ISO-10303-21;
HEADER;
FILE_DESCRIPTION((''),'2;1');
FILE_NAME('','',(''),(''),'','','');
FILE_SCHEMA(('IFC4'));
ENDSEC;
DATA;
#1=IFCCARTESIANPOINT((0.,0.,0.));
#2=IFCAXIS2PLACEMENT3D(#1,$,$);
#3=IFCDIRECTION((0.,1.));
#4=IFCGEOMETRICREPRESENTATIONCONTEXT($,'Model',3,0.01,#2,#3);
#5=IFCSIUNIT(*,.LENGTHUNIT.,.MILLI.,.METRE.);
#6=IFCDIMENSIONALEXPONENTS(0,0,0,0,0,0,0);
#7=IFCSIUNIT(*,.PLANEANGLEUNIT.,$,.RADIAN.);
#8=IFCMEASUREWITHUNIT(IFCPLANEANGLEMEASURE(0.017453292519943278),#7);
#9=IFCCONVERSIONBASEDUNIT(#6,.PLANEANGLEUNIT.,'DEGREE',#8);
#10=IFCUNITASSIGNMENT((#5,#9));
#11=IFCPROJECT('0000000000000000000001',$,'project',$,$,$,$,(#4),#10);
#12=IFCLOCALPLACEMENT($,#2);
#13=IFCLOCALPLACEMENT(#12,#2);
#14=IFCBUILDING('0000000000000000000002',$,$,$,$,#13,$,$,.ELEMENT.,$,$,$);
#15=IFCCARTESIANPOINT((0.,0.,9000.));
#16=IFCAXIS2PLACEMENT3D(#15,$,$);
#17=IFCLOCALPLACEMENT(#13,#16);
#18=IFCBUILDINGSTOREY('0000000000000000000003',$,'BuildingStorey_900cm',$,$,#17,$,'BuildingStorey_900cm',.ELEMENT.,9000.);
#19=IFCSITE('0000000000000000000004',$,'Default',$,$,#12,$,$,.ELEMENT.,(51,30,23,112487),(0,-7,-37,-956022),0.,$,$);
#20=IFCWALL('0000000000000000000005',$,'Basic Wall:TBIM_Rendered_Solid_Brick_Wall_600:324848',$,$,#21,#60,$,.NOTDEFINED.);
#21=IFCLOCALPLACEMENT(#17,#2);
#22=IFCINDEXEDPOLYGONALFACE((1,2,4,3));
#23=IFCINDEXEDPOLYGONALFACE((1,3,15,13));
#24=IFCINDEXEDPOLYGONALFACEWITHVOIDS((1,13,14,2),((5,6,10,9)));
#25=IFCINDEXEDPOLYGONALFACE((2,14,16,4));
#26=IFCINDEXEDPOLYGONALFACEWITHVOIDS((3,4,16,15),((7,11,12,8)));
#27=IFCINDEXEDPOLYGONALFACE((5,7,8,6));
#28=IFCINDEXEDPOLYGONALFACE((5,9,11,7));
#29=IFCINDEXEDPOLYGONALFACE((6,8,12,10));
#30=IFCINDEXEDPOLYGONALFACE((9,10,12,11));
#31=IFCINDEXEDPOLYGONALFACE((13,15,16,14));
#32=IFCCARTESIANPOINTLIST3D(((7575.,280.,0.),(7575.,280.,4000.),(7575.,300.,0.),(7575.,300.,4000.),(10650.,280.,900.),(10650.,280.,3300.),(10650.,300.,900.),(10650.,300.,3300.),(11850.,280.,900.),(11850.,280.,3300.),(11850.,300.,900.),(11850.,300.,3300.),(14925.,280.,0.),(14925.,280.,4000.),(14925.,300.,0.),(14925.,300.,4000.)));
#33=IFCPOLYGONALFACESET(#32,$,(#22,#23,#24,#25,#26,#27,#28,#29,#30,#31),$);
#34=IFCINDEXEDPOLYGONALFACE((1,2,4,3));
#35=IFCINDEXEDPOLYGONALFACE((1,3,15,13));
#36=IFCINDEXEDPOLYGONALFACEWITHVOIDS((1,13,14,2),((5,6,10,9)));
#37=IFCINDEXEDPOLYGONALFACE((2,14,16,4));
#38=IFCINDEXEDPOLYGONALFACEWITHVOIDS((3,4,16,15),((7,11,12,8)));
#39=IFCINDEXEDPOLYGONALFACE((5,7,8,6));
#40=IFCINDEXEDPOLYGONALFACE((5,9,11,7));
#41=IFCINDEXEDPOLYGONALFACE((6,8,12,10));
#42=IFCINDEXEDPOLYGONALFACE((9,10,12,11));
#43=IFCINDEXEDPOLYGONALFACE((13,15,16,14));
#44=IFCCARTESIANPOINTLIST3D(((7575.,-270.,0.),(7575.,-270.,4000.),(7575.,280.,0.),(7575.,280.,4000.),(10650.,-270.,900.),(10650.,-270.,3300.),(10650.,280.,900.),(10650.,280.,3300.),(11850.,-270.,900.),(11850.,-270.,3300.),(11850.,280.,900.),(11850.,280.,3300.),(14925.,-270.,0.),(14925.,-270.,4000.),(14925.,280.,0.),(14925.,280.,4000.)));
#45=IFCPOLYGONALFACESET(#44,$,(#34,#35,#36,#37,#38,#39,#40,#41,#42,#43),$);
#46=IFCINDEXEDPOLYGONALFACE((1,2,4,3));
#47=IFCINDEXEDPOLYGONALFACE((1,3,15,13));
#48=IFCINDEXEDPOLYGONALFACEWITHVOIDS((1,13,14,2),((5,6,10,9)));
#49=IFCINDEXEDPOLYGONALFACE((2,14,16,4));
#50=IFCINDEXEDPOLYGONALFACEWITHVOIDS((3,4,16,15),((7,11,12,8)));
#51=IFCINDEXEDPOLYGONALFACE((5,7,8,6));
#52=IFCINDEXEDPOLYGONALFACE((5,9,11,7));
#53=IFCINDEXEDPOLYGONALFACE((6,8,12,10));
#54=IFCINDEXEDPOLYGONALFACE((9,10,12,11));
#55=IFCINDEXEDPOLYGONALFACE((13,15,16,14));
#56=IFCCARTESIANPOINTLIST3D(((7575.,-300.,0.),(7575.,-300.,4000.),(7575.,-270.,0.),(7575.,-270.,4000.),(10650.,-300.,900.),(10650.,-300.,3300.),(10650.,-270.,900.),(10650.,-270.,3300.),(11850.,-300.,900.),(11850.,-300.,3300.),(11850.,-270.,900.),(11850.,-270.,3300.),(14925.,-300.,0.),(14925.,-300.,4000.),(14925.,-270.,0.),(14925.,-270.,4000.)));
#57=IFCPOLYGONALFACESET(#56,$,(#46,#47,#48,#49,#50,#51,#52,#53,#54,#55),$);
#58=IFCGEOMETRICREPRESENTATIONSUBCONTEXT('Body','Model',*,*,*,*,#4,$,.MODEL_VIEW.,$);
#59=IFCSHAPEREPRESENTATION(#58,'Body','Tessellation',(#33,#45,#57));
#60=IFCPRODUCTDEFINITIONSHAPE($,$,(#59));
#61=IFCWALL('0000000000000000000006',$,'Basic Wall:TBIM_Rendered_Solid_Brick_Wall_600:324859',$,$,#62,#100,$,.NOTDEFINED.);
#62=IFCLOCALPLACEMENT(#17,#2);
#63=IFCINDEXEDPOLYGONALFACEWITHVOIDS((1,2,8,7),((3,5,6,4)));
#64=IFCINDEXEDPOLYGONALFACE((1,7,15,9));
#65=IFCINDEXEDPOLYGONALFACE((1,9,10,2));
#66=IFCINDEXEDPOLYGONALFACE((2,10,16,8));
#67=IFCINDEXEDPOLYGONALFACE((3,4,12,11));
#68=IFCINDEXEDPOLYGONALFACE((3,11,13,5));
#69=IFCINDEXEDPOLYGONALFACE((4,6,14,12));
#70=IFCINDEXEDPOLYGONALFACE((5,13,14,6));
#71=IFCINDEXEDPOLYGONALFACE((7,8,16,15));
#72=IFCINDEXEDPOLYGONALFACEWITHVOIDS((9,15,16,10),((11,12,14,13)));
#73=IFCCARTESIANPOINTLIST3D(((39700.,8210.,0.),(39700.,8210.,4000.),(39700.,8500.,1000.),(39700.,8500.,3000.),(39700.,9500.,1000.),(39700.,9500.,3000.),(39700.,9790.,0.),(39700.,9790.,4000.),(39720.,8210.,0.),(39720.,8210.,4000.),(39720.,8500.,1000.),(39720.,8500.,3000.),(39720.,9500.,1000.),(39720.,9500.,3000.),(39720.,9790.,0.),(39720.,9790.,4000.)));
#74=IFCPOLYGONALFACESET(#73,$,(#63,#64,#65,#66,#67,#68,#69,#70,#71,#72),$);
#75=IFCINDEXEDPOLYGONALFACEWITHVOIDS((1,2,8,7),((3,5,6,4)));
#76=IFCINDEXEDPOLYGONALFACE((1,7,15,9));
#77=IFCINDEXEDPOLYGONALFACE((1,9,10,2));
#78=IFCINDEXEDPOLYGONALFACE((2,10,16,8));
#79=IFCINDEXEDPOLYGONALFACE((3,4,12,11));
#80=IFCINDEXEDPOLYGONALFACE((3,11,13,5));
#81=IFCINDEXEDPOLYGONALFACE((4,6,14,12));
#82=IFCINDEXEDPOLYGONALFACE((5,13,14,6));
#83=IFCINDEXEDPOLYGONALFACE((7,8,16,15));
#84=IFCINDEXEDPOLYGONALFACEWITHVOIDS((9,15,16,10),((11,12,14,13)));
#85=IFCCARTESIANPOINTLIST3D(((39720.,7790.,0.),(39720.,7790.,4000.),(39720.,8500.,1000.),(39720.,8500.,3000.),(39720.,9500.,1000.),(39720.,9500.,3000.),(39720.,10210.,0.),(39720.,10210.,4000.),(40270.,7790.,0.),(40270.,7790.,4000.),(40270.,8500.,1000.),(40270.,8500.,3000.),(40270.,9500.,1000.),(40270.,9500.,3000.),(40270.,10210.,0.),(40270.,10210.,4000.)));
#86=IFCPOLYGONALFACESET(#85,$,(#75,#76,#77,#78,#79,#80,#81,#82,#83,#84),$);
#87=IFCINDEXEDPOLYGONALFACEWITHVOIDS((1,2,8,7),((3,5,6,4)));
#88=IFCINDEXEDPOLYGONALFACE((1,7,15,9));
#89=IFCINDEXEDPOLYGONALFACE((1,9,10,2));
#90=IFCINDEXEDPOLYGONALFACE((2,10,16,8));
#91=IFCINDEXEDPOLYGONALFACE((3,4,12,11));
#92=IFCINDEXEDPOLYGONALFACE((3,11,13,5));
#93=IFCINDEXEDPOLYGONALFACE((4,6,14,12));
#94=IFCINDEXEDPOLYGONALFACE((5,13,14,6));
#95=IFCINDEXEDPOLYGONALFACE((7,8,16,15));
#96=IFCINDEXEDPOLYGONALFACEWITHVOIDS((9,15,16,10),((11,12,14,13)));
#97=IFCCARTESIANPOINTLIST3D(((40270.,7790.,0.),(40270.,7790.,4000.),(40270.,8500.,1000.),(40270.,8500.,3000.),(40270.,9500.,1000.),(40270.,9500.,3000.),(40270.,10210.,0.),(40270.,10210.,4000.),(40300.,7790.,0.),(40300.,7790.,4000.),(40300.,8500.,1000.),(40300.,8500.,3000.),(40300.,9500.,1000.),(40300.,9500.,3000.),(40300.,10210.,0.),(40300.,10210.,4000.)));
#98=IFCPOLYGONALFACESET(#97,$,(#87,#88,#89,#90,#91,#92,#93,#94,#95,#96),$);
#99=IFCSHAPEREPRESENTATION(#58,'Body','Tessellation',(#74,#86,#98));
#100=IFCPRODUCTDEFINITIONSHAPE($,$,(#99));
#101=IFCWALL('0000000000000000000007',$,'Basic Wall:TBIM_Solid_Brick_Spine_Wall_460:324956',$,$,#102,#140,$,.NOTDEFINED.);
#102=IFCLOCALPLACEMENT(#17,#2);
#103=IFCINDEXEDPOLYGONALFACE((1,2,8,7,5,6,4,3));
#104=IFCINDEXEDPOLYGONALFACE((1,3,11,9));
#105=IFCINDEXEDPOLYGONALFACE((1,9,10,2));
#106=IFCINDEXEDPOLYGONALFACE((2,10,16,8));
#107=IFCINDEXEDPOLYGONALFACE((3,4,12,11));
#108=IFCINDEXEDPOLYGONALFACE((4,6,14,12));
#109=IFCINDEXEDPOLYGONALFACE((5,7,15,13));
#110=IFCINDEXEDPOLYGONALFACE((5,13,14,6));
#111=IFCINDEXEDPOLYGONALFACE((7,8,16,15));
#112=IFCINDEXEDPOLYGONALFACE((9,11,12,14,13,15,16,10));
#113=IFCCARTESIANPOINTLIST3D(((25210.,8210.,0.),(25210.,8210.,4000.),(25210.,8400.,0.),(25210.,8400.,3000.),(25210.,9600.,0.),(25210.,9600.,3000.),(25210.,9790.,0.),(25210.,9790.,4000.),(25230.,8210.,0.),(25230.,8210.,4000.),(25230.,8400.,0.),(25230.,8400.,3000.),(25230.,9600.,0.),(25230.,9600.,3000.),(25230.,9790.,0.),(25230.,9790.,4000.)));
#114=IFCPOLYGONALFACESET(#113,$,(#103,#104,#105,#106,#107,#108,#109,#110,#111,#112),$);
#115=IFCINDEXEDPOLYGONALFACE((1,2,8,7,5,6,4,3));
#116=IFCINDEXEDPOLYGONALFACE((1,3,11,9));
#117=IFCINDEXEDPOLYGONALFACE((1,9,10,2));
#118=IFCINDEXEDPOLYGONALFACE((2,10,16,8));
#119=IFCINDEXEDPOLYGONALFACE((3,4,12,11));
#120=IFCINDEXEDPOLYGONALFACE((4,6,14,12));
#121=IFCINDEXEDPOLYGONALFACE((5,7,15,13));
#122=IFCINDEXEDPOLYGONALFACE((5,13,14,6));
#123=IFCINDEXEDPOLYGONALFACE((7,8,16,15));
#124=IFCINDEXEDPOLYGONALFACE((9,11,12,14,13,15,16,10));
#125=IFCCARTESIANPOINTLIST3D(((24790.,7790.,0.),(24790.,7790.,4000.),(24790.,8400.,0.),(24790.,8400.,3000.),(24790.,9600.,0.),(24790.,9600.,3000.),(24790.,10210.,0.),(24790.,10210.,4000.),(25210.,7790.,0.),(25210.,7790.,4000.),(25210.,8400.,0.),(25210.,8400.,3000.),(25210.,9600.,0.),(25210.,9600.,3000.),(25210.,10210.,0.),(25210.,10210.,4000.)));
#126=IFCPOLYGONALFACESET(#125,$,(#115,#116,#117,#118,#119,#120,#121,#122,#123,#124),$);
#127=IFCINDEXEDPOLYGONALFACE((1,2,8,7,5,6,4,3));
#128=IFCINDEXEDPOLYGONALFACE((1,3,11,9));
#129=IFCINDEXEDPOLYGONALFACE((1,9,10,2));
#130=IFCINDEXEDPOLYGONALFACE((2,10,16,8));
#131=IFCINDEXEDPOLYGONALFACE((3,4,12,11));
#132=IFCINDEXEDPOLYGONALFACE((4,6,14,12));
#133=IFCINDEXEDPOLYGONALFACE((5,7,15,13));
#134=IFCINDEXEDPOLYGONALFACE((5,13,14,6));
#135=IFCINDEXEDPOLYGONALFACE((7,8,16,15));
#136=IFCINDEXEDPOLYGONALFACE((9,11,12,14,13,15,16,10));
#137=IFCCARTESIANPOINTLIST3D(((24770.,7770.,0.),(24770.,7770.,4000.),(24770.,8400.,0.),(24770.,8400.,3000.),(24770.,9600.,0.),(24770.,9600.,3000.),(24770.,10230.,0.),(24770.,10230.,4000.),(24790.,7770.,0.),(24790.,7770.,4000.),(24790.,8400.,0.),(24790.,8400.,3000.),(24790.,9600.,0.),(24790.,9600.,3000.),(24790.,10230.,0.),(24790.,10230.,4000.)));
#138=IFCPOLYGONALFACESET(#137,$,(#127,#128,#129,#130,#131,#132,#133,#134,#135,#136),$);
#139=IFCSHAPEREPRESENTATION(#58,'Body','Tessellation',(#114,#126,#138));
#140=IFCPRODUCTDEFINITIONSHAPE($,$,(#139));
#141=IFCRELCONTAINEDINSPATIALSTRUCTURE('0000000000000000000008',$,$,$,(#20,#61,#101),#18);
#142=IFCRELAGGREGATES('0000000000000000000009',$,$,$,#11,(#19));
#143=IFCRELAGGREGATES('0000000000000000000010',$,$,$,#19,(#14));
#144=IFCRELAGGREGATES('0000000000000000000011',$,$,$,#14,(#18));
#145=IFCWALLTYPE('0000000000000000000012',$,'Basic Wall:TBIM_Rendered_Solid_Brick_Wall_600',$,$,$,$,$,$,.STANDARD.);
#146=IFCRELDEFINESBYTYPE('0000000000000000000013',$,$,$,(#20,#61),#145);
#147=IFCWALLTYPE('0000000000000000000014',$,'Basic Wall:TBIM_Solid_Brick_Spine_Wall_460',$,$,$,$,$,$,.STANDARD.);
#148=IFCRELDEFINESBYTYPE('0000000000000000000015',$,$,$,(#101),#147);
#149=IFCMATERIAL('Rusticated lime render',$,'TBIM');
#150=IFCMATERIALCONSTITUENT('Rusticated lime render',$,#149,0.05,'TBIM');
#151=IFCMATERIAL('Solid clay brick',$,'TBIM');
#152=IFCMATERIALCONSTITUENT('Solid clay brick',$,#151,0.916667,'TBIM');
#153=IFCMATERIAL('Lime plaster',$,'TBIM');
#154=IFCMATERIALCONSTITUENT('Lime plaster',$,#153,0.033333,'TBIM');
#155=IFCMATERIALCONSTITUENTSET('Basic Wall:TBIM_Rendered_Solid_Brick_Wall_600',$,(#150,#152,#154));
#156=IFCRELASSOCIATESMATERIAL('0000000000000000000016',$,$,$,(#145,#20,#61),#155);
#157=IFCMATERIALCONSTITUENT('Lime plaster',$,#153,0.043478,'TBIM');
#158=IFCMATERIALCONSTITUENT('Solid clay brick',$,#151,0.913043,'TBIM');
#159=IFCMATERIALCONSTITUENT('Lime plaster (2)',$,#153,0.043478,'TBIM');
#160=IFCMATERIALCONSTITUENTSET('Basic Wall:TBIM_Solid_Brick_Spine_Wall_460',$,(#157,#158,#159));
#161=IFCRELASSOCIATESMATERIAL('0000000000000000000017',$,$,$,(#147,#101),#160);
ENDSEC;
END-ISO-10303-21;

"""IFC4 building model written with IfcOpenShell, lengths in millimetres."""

from ifc_helpers import new_model, entity, si_unit, converted_unit, direction, frame, origin, place, context, subcontext, project, spatial, indexed_curve, outline, extrude, material, constituent, constituent_set, type_object, element, save


model = new_model("IFC4")

# Units and contexts
model_context = context("Model", 3, precision=0.01, world=origin(), true_north=direction((0.0, 1.0)))
body_context = subcontext(model_context, "Body", "Model", "MODEL_VIEW")
ifc_project = project(units=[si_unit("LENGTHUNIT", "METRE", prefix="MILLI"), converted_unit("PLANEANGLEUNIT", "DEGREE", entity("IfcPlaneAngleMeasure", 0.017453292519943278), si_unit("PLANEANGLEUNIT", "RADIAN"), dimensions=[0, 0, 0, 0, 0, 0, 0])], contexts=[model_context])

# Site, building, storey
site_placement = place(None, origin())
site = spatial("IfcSite", under=ifc_project, at=site_placement, Name="Default", CompositionType="ELEMENT", RefLatitude=(51, 30, 23, 112487), RefLongitude=(0, -7, -37, -956022), RefElevation=0.0)
building_placement = place(site_placement, origin())
building = spatial("IfcBuilding", under=site, at=building_placement, CompositionType="ELEMENT")
storey_placement = place(building_placement, frame((0.0, 0.0, 9000.0)))
storey = spatial("IfcBuildingStorey", under=building, at=storey_placement, Name="BuildingStorey_900cm", LongName="BuildingStorey_900cm", CompositionType="ELEMENT", Elevation=9000.0)

# Walls, openings
ifc_material_1 = material(Name="Rusticated lime render", Category="TBIM")
ifc_constituent_1 = constituent(ifc_material_1, Name="Rusticated lime render", Category="TBIM", fraction=0.05)
ifc_material_2 = material(Name="Solid clay brick", Category="TBIM")
ifc_constituent_2 = constituent(ifc_material_2, Name="Solid clay brick", Category="TBIM", fraction=0.916667)
ifc_material_3 = material(Name="Lime plaster", Category="TBIM")
ifc_constituent_3 = constituent(ifc_material_3, Name="Lime plaster", Category="TBIM", fraction=0.033333)
ifc_constituent_set_1 = constituent_set(constituents=[ifc_constituent_1, ifc_constituent_2, ifc_constituent_3], Name="Basic Wall:TBIM_Rendered_Solid_Brick_Wall_600")
wall_type_1 = type_object("IfcWallType", Name="Basic Wall:TBIM_Rendered_Solid_Brick_Wall_600", PredefinedType="STANDARD", material=ifc_constituent_set_1)
wall_1_placement = place(storey_placement, frame((7575.0, 0.0, 0.0)))
wall_1 = element("IfcWall", 1, at=wall_1_placement, inside=storey, type_object=wall_type_1, material=ifc_constituent_set_1, Name="Basic Wall:TBIM_Rendered_Solid_Brick_Wall_600:324848", PredefinedType="NOTDEFINED", context=body_context, shape_type="SweptSolid", body=[
    extrude(outline(indexed_curve([(-2000.0, -3675.0), (2000.0, -3675.0), (2000.0, 3675.0), (-2000.0, 3675.0), (-2000.0, -3675.0)], self_intersect=False), holes=[indexed_curve([(-1100.0, -600.0), (-1100.0, 600.0), (1300.0, 600.0), (1300.0, -600.0), (-1100.0, -600.0)], self_intersect=False)]), frame((3675.0, 280.0, 2000.0), z_axis=(0.0, 1.0, 0.0), x_axis=(0.0, 0.0, 1.0)), (0.0, 0.0, 1.0), 20.0),
    extrude(outline(indexed_curve([(-2000.0, -3675.0), (2000.0, -3675.0), (2000.0, 3675.0), (-2000.0, 3675.0), (-2000.0, -3675.0)], self_intersect=False), holes=[indexed_curve([(-1100.0, -600.0), (-1100.0, 600.0), (1300.0, 600.0), (1300.0, -600.0), (-1100.0, -600.0)], self_intersect=False)]), frame((3675.0, -270.0, 2000.0), z_axis=(0.0, 1.0, 0.0), x_axis=(0.0, 0.0, 1.0)), (0.0, 0.0, 1.0), 550.0),
    extrude(outline(indexed_curve([(-2000.0, -3675.0), (2000.0, -3675.0), (2000.0, 3675.0), (-2000.0, 3675.0), (-2000.0, -3675.0)], self_intersect=False), holes=[indexed_curve([(1300.0, -600.0), (-1100.0, -600.0), (-1100.0, 600.0), (1300.0, 600.0), (1300.0, -600.0)], self_intersect=False)]), frame((3675.0, -300.0, 2000.0), z_axis=(0.0, 1.0, 0.0), x_axis=(0.0, 0.0, 1.0)), (0.0, 0.0, 1.0), 30.0),
])
opening_1_placement = place(wall_1_placement, frame((3075.0, -300.0, 900.0)))
element("IfcOpeningElement", 2, at=opening_1_placement, cuts=wall_1, PredefinedType="OPENING", context=body_context, shape_type="SweptSolid", body=[
    extrude(outline(indexed_curve([(2400.0, 0.0), (2400.0, 1200.0), (0.0, 1200.0), (0.0, 0.0), (2400.0, 0.0)], self_intersect=False)), frame((0.0, 0.0, 0.0), z_axis=(0.0, 1.0, 0.0), x_axis=(0.0, 0.0, 1.0)), (0.0, 0.0, 1.0), 600.0),
])
wall_2_placement = place(storey_placement, frame((40000.0, 10230.0, 0.0), z_axis=(0.0, 0.0, 1.0), x_axis=(0.0, -1.0, 0.0)))
wall_2 = element("IfcWall", 3, at=wall_2_placement, inside=storey, type_object=wall_type_1, material=ifc_constituent_set_1, Name="Basic Wall:TBIM_Rendered_Solid_Brick_Wall_600:324859", PredefinedType="NOTDEFINED", context=body_context, shape_type="SweptSolid", body=[
    extrude(outline(indexed_curve([(-2000.0, -790.0), (2000.0, -790.0), (2000.0, -770.0), (2000.0, 770.0), (2000.0, 790.0), (-2000.0, 790.0), (-2000.0, 770.0), (-2000.0, -770.0), (-2000.0, -790.0)], self_intersect=False), holes=[indexed_curve([(1000.0, -500.0), (-1000.0, -500.0), (-1000.0, 500.0), (1000.0, 500.0), (1000.0, -500.0)], self_intersect=False)]), frame((1230.0, -300.0, 2000.0), z_axis=(0.0, 1.0, 0.0), x_axis=(0.0, 0.0, 1.0)), (0.0, 0.0, 1.0), 20.0),
    extrude(outline(indexed_curve([(-2000.0, -1210.0), (2000.0, -1210.0), (2000.0, 1210.0), (-2000.0, 1210.0), (-2000.0, -1210.0)], self_intersect=False), holes=[indexed_curve([(-1000.0, -500.0), (-1000.0, 500.0), (1000.0, 500.0), (1000.0, -500.0), (-1000.0, -500.0)], self_intersect=False)]), frame((1230.0, -280.0, 2000.0), z_axis=(0.0, 1.0, 0.0), x_axis=(0.0, 0.0, 1.0)), (0.0, 0.0, 1.0), 550.0),
    extrude(outline(indexed_curve([(-2000.0, -1210.0), (2000.0, -1210.0), (2000.0, 1210.0), (-2000.0, 1210.0), (-2000.0, -1210.0)], self_intersect=False), holes=[indexed_curve([(-1000.0, -500.0), (-1000.0, 500.0), (1000.0, 500.0), (1000.0, -500.0), (-1000.0, -500.0)], self_intersect=False)]), frame((1230.0, 270.0, 2000.0), z_axis=(0.0, 1.0, 0.0), x_axis=(0.0, 0.0, 1.0)), (0.0, 0.0, 1.0), 30.0),
])
opening_2_placement = place(wall_2_placement, frame((730.0, -300.0, 1000.0)))
element("IfcOpeningElement", 4, at=opening_2_placement, cuts=wall_2, PredefinedType="OPENING", context=body_context, shape_type="SweptSolid", body=[
    extrude(outline(indexed_curve([(2000.0, 0.0), (2000.0, 1000.0), (0.0, 1000.0), (0.0, 0.0), (2000.0, 0.0)], self_intersect=False)), frame((0.0, 0.0, 0.0), z_axis=(0.0, 1.0, 0.0), x_axis=(0.0, 0.0, 1.0)), (0.0, 0.0, 1.0), 600.0),
])
ifc_constituent_4 = constituent(ifc_material_3, Name="Lime plaster", Category="TBIM", fraction=0.043478)
ifc_constituent_5 = constituent(ifc_material_2, Name="Solid clay brick", Category="TBIM", fraction=0.913043)
ifc_constituent_6 = constituent(ifc_material_3, Name="Lime plaster (2)", Category="TBIM", fraction=0.043478)
ifc_constituent_set_2 = constituent_set(constituents=[ifc_constituent_4, ifc_constituent_5, ifc_constituent_6], Name="Basic Wall:TBIM_Solid_Brick_Spine_Wall_460")
wall_type_2 = type_object("IfcWallType", Name="Basic Wall:TBIM_Solid_Brick_Spine_Wall_460", PredefinedType="STANDARD", material=ifc_constituent_set_2)
wall_3_placement = place(storey_placement, frame((25000.0, 10230.0, 0.0), z_axis=(0.0, 0.0, 1.0), x_axis=(0.0, -1.0, 0.0)))
wall_3 = element("IfcWall", 5, at=wall_3_placement, inside=storey, type_object=wall_type_2, material=ifc_constituent_set_2, Name="Basic Wall:TBIM_Solid_Brick_Spine_Wall_460:324956", PredefinedType="NOTDEFINED", context=body_context, shape_type="SweptSolid", body=[
    extrude(outline(indexed_curve([(-1750.0, -790.0), (2250.0, -790.0), (2250.0, 790.0), (-1750.0, 790.0), (-1750.0, 600.0), (1250.0, 600.0), (1250.0, -600.0), (-1750.0, -600.0), (-1750.0, -790.0)], self_intersect=False)), frame((1230.0, 210.0, 1750.0), z_axis=(0.0, 1.0, 0.0), x_axis=(0.0, 0.0, 1.0)), (0.0, 0.0, 1.0), 20.0),
    extrude(outline(indexed_curve([(-1750.0, -1210.0), (2250.0, -1210.0), (2250.0, 1210.0), (-1750.0, 1210.0), (-1750.0, 600.0), (1250.0, 600.0), (1250.0, -600.0), (-1750.0, -600.0), (-1750.0, -1210.0)], self_intersect=False)), frame((1230.0, -210.0, 1750.0), z_axis=(0.0, 1.0, 0.0), x_axis=(0.0, 0.0, 1.0)), (0.0, 0.0, 1.0), 420.0),
    extrude(outline(indexed_curve([(-2250.0, -1230.0), (1750.0, -1230.0), (1750.0, -600.0), (-1250.0, -600.0), (-1250.0, 600.0), (1750.0, 600.0), (1750.0, 1230.0), (-2250.0, 1230.0), (-2250.0, -1230.0)], self_intersect=False)), frame((1230.0, -230.0, 1750.0), z_axis=(0.0, 1.0, 0.0), x_axis=(0.0, 0.0, -1.0)), (0.0, 0.0, 1.0), 20.0),
])
opening_3_placement = place(wall_3_placement, frame((630.0, -230.0, 0.0)))
element("IfcOpeningElement", 6, at=opening_3_placement, cuts=wall_3, PredefinedType="OPENING", context=body_context, shape_type="SweptSolid", body=[
    extrude(outline(indexed_curve([(0.0, 1200.0), (0.0, 0.0), (3000.0, 0.0), (3000.0, 1200.0), (0.0, 1200.0)], self_intersect=False)), frame((0.0, 0.0, 0.0), z_axis=(0.0, 1.0, 0.0), x_axis=(0.0, 0.0, 1.0)), (0.0, 0.0, 1.0), 460.0),
])

save(model, "model.ifc")
